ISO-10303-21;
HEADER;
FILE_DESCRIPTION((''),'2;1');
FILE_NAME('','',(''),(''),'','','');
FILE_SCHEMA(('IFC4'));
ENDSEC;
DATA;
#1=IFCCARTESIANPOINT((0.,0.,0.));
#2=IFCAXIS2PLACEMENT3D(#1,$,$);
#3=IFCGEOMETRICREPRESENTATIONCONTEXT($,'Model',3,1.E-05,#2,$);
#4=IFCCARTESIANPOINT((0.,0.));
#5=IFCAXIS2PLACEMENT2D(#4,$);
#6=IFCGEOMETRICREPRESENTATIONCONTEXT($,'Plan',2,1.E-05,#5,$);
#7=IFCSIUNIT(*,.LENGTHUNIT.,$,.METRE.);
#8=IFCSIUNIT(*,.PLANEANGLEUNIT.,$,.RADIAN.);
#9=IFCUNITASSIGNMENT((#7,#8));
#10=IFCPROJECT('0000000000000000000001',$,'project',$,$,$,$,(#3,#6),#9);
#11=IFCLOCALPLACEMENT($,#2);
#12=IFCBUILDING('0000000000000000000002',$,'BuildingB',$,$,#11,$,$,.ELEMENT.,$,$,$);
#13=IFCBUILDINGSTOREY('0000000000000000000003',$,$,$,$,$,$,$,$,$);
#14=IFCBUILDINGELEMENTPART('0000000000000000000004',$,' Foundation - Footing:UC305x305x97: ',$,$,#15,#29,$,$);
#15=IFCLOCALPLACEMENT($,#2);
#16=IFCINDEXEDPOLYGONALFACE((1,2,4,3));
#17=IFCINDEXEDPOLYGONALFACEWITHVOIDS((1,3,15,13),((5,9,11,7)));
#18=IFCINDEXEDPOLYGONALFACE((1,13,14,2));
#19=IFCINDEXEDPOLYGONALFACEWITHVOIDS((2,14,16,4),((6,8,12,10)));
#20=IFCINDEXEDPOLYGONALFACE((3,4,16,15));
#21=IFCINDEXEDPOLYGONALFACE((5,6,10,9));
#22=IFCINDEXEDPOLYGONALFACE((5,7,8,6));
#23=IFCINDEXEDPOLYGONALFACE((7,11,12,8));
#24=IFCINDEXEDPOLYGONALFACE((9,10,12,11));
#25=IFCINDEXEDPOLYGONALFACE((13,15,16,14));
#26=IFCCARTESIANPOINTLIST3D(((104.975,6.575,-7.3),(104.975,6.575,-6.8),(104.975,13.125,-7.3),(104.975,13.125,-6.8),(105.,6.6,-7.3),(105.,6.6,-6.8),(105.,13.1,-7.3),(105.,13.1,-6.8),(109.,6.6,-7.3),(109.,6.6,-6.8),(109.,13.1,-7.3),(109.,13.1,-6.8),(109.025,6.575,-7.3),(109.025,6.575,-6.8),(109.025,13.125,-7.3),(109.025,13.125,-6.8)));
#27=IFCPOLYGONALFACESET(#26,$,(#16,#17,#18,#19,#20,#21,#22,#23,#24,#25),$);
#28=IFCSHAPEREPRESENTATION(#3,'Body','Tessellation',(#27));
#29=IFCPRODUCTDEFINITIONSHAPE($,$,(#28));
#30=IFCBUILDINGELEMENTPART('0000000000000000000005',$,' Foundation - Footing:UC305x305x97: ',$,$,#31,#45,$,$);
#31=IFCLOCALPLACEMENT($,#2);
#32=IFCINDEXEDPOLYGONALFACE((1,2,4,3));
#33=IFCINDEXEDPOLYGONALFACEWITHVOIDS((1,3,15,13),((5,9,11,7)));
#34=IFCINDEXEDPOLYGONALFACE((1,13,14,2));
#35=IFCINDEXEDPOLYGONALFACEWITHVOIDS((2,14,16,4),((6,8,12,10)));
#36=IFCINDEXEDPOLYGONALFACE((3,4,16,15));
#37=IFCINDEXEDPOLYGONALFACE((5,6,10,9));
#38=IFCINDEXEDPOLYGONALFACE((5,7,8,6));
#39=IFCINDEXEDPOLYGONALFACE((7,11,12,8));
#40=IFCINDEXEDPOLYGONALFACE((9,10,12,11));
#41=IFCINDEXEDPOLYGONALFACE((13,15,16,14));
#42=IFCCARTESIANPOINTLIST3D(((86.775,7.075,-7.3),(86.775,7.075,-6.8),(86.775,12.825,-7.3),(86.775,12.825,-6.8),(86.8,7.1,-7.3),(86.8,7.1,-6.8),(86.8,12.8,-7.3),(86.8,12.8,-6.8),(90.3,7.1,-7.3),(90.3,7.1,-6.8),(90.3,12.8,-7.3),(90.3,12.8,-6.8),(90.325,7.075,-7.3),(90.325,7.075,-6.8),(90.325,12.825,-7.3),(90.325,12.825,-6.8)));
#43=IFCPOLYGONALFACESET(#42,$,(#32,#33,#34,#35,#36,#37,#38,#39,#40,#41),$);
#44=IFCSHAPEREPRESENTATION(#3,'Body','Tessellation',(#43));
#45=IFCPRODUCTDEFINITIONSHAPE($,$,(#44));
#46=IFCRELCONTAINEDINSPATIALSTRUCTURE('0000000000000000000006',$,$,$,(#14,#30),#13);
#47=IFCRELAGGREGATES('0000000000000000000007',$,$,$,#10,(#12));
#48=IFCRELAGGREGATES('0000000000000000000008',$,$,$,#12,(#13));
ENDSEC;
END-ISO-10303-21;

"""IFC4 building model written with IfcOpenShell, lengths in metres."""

from ifc_helpers import new_model, si_unit, origin, origin_2d, place, context, project, spatial, polyline, outline, extrude, element, save


model = new_model("IFC4")

# Units and contexts
model_context = context("Model", 3, precision=1e-05, world=origin())
plan_context = context("Plan", 2, precision=1e-05, world=origin_2d())
ifc_project = project(units=[si_unit("LENGTHUNIT", "METRE"), si_unit("PLANEANGLEUNIT", "RADIAN")], contexts=[model_context, plan_context])

# Building, storey
building_placement = place(None, origin())
building = spatial("IfcBuilding", under=ifc_project, at=building_placement, Name="BuildingB", CompositionType="ELEMENT")
storey = spatial("IfcBuildingStorey", under=building)

# Building element parts, openings
building_element_part_1 = element("IfcBuildingElementPart", 1, inside=storey, Name=" Foundation - Footing:UC305x305x97: ", context=model_context, shape_type="SweptSolid", body=[
    extrude(outline(polyline([(109.025, 13.125, -7.3), (104.975, 13.125, -7.3), (104.975, 6.575, -7.3), (109.025, 6.575, -7.3), (109.025, 13.125, -7.3)])), None, (0.0, 0.0, 1.0), 0.5),
])
element("IfcOpeningElement", 2, inside=storey, cuts=building_element_part_1, context=model_context, shape_type="SweptSolid", body=[
    extrude(outline(polyline([(109.0, 13.1, -7.3), (105.0, 13.1, -7.3), (105.0, 6.6, -7.3), (109.0, 6.6, -7.3), (109.0, 13.1, -7.3)])), None, (0.0, 0.0, 1.0), 0.5),
])
building_element_part_2 = element("IfcBuildingElementPart", 3, inside=storey, Name=" Foundation - Footing:UC305x305x97: ", context=model_context, shape_type="SweptSolid", body=[
    extrude(outline(polyline([(86.775, 12.825, -7.3), (90.325, 12.825, -7.3), (90.325, 7.075, -7.3), (86.775, 7.075, -7.3), (86.775, 12.825, -7.3)])), None, (0.0, 0.0, 1.0), 0.5),
])
element("IfcOpeningElement", 4, inside=storey, cuts=building_element_part_2, context=model_context, shape_type="SweptSolid", body=[
    extrude(outline(polyline([(86.8, 12.8, -7.3), (90.3, 12.8, -7.3), (90.3, 7.1, -7.3), (86.8, 7.1, -7.3), (86.8, 12.8, -7.3)])), None, (0.0, 0.0, 1.0), 0.5),
])

save(model, "model.ifc")
